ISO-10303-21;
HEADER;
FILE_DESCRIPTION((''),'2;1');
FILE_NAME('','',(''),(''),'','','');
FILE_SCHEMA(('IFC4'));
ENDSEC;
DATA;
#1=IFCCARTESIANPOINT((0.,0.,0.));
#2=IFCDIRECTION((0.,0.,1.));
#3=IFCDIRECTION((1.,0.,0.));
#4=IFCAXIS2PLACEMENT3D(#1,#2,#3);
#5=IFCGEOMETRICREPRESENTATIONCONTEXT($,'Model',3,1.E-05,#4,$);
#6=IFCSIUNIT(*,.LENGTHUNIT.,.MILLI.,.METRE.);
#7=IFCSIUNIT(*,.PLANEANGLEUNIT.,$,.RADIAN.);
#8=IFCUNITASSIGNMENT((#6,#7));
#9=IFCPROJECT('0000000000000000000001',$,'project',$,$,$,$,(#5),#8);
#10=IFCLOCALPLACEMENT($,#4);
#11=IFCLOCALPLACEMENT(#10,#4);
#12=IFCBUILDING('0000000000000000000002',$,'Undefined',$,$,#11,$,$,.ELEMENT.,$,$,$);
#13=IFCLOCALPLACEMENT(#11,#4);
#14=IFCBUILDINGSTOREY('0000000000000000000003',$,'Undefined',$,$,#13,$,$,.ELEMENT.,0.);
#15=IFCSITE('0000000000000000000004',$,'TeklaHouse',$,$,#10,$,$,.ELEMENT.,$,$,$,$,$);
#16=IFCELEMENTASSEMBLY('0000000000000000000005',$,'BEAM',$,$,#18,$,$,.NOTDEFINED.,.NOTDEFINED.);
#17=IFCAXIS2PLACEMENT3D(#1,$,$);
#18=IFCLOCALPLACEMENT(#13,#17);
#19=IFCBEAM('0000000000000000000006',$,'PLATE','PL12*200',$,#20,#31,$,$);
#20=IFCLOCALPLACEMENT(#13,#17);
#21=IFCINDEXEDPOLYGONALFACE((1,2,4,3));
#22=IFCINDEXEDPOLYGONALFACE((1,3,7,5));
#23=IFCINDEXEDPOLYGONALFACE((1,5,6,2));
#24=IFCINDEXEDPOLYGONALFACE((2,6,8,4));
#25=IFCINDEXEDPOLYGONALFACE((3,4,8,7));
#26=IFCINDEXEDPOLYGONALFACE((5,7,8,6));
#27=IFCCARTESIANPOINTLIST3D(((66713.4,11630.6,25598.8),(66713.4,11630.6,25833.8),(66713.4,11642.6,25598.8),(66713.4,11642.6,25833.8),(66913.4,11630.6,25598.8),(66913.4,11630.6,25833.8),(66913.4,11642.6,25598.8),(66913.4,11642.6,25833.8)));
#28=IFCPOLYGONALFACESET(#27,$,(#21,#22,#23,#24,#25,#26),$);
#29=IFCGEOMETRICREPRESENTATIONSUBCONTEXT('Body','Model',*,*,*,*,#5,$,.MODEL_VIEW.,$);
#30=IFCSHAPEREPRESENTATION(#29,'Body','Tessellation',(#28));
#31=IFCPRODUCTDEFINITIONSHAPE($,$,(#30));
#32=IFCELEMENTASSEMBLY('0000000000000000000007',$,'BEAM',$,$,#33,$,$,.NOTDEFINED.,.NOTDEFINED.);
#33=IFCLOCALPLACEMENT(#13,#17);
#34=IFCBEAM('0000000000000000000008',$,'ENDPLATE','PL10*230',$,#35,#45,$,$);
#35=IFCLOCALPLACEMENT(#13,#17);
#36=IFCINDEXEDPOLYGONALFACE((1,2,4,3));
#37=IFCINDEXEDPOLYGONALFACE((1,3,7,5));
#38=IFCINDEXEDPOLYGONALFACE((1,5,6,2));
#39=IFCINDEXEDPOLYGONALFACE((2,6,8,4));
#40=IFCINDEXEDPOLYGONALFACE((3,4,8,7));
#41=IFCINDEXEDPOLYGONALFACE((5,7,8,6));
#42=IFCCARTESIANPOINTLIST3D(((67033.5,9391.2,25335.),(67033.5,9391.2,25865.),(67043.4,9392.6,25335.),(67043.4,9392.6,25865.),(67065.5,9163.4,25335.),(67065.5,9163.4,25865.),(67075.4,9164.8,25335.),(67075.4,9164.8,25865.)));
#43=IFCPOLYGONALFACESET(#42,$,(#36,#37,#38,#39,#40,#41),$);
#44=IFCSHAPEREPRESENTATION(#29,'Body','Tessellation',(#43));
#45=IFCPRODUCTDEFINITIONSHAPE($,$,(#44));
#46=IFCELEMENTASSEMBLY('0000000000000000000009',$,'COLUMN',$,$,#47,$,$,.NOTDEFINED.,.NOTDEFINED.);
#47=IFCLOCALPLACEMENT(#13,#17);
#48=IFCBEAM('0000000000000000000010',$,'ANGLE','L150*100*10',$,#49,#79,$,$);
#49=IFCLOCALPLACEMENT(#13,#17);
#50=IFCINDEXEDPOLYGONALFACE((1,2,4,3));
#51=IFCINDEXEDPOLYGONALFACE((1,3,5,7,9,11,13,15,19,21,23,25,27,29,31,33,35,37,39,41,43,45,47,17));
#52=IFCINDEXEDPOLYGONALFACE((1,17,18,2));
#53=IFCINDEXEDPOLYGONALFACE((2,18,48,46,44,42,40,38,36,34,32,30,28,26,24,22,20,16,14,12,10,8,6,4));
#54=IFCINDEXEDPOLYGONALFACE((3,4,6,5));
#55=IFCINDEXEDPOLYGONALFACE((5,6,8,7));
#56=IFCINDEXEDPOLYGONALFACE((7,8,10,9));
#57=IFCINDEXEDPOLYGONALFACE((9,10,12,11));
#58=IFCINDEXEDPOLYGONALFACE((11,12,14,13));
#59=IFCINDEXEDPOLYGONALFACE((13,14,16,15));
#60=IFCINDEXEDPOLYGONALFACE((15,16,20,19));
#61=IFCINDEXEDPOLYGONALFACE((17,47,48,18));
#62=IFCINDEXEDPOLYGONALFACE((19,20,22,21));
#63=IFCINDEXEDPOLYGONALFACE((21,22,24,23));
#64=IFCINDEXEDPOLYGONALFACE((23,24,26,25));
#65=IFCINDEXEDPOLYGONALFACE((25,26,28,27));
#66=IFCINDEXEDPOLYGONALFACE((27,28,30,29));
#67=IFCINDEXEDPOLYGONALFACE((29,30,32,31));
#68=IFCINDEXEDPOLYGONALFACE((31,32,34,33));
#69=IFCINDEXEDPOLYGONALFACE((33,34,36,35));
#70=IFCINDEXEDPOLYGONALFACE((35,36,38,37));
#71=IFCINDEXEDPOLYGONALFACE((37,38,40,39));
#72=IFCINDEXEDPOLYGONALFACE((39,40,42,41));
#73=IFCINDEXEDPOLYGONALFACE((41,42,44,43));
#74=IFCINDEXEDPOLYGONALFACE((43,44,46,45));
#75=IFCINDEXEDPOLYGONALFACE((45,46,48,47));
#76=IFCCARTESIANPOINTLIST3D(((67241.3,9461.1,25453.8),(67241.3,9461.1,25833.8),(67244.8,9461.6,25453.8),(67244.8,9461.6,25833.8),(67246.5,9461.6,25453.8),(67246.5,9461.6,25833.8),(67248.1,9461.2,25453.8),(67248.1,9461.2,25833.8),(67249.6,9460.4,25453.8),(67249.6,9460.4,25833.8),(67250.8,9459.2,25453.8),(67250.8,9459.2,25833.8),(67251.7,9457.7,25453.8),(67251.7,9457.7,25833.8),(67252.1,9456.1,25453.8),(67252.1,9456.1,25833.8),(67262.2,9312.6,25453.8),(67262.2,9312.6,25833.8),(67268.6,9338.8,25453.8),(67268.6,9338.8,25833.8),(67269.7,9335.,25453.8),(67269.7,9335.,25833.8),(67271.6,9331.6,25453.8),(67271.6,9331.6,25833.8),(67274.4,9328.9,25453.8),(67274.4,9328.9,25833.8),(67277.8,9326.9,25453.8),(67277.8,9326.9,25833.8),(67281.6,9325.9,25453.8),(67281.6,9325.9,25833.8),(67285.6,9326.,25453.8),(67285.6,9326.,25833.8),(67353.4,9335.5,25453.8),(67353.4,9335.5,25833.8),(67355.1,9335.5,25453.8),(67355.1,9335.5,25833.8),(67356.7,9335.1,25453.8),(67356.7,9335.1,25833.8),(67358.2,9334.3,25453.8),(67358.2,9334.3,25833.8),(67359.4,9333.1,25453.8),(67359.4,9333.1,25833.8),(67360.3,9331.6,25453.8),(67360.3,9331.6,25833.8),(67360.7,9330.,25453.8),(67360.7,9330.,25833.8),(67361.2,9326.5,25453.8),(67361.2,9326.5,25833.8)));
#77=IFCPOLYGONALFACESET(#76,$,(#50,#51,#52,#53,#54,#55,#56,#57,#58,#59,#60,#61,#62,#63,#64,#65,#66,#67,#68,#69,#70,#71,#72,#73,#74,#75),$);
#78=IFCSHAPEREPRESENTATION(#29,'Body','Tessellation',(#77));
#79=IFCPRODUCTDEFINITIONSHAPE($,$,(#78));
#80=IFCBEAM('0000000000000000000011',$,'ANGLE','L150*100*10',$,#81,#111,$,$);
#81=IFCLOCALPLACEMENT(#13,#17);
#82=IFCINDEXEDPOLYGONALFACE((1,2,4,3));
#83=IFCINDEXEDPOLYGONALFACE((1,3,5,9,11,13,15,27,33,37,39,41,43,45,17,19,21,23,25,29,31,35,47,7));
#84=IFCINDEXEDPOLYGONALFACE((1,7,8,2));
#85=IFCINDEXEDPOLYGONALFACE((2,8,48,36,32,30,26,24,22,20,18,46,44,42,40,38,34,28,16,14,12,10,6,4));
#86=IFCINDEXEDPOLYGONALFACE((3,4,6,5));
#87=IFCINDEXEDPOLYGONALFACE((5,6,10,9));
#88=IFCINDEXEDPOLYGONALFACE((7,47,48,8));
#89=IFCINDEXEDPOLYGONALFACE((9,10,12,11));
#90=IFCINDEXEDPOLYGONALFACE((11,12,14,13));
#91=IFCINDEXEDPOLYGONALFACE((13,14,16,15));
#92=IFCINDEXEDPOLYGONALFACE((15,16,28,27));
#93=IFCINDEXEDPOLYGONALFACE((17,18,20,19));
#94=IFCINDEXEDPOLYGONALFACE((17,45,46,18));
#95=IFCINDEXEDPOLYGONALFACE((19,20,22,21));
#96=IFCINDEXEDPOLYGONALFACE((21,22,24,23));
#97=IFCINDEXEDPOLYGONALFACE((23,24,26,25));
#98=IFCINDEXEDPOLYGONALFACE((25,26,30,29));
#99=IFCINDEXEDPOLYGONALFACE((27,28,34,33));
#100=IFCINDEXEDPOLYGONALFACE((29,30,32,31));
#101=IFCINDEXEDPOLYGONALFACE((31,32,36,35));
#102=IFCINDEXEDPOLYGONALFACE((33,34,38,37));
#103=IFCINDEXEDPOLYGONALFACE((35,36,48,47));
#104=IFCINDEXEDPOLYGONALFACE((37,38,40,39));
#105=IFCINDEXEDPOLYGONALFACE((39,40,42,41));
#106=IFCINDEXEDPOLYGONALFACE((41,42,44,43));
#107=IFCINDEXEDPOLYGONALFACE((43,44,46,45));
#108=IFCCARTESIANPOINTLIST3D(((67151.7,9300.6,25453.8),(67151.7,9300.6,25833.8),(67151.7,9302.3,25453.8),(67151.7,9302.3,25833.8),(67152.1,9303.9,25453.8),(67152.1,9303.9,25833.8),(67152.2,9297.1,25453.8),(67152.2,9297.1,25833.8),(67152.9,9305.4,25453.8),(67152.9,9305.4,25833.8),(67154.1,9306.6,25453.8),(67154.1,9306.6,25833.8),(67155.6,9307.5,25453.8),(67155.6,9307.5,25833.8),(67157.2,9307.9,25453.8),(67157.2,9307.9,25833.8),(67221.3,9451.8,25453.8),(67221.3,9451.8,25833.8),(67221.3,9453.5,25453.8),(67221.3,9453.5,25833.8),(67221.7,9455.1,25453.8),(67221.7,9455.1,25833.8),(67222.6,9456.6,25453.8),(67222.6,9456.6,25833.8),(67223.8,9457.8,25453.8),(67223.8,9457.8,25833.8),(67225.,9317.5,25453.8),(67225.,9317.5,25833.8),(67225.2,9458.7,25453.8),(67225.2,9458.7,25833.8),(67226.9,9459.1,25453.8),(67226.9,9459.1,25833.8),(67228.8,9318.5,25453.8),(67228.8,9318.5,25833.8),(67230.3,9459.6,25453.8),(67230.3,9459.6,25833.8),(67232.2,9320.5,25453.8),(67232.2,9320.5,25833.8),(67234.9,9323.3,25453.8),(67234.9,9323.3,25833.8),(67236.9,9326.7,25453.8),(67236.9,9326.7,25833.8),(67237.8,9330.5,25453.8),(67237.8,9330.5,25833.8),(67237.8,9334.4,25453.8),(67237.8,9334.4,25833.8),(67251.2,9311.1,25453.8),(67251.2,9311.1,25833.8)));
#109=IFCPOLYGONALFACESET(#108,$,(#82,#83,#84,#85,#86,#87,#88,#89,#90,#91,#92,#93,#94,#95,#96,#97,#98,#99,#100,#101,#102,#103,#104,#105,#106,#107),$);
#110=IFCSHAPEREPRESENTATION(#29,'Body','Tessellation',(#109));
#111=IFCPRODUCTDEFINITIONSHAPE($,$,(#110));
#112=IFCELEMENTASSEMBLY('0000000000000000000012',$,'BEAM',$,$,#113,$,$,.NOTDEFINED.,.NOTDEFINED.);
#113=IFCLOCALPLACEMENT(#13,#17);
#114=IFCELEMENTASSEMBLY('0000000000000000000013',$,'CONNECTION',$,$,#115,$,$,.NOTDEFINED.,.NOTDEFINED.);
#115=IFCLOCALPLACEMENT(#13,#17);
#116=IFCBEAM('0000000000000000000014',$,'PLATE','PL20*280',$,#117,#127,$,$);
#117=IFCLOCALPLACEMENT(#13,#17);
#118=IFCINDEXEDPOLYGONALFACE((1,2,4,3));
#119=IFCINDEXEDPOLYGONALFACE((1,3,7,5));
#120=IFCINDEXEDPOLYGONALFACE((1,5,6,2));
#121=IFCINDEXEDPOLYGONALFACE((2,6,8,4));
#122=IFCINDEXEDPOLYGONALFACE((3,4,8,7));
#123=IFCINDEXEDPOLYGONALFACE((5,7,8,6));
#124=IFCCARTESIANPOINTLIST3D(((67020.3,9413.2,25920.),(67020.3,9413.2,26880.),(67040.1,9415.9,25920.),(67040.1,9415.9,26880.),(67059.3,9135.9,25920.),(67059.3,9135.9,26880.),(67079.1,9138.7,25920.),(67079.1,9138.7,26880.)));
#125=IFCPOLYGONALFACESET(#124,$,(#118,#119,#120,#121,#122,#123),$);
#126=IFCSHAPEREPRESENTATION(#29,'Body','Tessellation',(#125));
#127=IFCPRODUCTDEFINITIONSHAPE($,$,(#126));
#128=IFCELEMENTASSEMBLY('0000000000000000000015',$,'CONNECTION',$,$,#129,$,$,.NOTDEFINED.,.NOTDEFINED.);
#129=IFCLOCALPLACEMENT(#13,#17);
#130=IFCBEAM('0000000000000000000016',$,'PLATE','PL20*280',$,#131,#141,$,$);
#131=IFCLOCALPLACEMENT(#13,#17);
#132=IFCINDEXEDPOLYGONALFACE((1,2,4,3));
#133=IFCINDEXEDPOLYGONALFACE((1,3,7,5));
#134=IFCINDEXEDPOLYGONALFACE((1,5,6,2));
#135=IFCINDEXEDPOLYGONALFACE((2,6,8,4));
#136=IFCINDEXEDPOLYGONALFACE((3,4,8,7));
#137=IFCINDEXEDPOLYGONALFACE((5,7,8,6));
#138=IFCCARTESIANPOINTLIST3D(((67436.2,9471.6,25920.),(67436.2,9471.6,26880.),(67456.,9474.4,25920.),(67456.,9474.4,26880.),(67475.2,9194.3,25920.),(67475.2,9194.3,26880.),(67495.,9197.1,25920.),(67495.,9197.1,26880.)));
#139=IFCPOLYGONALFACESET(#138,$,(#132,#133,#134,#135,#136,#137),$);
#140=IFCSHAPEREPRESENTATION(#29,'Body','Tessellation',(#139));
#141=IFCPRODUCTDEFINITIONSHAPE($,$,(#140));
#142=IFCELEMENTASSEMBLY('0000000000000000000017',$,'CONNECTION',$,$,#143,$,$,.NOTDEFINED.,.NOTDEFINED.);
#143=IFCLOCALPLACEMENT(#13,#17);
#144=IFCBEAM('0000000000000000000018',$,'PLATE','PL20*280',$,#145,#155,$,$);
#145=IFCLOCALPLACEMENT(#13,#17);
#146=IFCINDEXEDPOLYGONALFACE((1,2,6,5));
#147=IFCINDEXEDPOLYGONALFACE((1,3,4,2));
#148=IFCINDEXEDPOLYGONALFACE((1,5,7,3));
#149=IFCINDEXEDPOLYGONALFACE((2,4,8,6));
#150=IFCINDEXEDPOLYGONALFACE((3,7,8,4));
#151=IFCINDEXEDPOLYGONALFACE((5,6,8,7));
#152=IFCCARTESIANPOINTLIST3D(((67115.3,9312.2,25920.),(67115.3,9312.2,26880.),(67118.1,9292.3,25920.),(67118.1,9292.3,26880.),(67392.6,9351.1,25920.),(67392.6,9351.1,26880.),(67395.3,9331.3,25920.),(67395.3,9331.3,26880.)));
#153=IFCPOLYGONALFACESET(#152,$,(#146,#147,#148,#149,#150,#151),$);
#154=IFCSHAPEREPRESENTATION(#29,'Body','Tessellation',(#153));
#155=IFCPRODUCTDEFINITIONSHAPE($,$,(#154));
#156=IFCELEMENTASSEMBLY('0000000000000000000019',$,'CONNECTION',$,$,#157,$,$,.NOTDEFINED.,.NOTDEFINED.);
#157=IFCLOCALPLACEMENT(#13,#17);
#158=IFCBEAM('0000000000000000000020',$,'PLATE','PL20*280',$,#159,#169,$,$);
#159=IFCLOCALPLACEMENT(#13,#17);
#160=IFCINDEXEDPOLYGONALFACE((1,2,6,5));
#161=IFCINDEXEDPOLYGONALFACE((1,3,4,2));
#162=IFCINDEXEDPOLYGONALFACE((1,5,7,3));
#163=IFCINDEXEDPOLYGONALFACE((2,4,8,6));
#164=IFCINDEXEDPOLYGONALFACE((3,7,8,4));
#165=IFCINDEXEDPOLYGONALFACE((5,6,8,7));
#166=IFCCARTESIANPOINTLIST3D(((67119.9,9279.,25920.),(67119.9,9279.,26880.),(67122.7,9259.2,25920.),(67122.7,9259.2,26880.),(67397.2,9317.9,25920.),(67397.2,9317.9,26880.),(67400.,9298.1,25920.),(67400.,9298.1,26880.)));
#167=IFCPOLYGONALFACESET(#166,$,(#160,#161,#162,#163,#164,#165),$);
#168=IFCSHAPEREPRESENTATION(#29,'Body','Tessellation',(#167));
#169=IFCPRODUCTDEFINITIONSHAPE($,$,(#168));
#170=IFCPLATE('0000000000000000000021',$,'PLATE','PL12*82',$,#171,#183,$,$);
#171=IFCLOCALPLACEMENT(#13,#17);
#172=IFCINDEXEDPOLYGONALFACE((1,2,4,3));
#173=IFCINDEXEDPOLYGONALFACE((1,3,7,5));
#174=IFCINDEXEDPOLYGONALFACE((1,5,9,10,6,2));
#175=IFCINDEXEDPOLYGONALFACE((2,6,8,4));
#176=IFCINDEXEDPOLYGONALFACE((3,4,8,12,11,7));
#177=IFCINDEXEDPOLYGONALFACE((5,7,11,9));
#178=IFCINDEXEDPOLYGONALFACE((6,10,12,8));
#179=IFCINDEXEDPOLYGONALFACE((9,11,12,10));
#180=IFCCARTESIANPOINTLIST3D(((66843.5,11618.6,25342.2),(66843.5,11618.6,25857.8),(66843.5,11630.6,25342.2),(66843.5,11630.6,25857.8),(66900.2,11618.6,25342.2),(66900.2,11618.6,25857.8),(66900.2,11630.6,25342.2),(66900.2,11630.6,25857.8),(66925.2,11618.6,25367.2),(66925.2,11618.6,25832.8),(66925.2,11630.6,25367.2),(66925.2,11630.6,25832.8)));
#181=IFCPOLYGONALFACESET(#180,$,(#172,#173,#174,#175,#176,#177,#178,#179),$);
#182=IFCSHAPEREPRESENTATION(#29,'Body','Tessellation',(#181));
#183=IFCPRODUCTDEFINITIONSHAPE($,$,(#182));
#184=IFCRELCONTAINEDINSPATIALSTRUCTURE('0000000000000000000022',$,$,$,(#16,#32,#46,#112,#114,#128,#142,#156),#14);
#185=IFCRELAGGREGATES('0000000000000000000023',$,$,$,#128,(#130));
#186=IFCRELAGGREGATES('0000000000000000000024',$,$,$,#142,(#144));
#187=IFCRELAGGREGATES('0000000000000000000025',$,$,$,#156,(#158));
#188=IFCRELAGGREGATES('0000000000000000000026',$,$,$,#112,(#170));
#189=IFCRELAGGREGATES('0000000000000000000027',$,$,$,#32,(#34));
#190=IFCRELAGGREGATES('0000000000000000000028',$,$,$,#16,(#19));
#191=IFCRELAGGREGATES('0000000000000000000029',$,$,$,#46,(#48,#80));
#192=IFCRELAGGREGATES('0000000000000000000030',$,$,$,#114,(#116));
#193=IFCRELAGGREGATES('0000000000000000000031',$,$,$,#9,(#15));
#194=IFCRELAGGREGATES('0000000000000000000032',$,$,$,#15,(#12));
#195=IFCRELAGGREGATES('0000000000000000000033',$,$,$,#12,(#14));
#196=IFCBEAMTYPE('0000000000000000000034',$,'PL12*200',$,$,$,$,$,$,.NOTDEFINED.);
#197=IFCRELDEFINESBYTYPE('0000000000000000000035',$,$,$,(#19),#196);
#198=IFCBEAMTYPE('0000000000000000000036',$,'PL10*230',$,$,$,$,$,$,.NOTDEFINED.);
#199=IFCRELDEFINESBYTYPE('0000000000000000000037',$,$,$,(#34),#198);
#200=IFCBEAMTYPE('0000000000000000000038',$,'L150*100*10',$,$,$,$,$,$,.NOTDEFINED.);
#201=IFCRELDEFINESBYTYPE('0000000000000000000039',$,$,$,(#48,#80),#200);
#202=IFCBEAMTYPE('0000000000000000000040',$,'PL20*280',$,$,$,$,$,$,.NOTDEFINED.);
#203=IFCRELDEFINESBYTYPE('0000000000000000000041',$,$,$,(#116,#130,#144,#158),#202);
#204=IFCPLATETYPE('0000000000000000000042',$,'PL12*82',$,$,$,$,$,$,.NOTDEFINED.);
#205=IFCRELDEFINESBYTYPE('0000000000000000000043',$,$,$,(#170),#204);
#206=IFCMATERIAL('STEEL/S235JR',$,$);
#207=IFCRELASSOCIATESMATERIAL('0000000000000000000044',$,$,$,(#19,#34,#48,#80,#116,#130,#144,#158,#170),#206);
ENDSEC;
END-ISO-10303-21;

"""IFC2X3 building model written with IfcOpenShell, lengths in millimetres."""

from ifc_helpers import new_model, si_unit, frame, origin_with_axes, origin_2d_with_axis, place, context, subcontext, project, spatial, polyline, rectangle, l_section, outline, extrude, material, type_object, element, aggregate, save


model = new_model("IFC2X3")

# Units and contexts
model_context = context("Model", 3, precision=1e-05, world=origin_with_axes())
body_context = subcontext(model_context, "Body", "Model", "MODEL_VIEW")
ifc_project = project(units=[si_unit("LENGTHUNIT", "METRE", prefix="MILLI"), si_unit("PLANEANGLEUNIT", "RADIAN")], contexts=[model_context])

# Site, building, storey
site_placement = place(None, origin_with_axes())
site = spatial("IfcSite", under=ifc_project, at=site_placement, Name="TeklaHouse", CompositionType="ELEMENT")
building_placement = place(site_placement, origin_with_axes())
building = spatial("IfcBuilding", under=site, at=building_placement, Name="Undefined", CompositionType="ELEMENT")
storey_placement = place(building_placement, origin_with_axes())
storey = spatial("IfcBuildingStorey", under=building, at=storey_placement, Name="Undefined", CompositionType="ELEMENT", Elevation=0.0)

# Element assemblies, beams
assembly_1_placement = place(storey_placement, origin_with_axes())
assembly_1 = element("IfcElementAssembly", 1, at=assembly_1_placement, inside=storey, Name="BEAM", AssemblyPlace="NOTDEFINED", PredefinedType="NOTDEFINED")
ifc_material_1 = material(Name="STEEL/S235JR")
beam_type_1 = type_object("IfcBeamType", Name="PL12*200", PredefinedType="NOTDEFINED")
beam_1_placement = place(assembly_1_placement, frame((66813.4, 11636.6, 25598.8), z_axis=(1.0, 0.0, 0.0), x_axis=(0.0, 0.0, 1.0)))
beam_1 = element("IfcBeam", 2, at=beam_1_placement, type_object=beam_type_1, material=ifc_material_1, Name="PLATE", Description="PL12*200", context=body_context, shape_type="SweptSolid", body=[
    extrude(rectangle(XDim=12.0, YDim=200.0, at=origin_2d_with_axis()), frame((235.0, 0.0, 0.0), z_axis=(-1.0, 0.0, 0.0), x_axis=(0.0, -1.0, 0.0)), (0.0, 0.0, 1.0), 235.0),
])
assembly_2_placement = place(storey_placement, origin_with_axes())
assembly_2 = element("IfcElementAssembly", 3, at=assembly_2_placement, inside=storey, Name="BEAM", AssemblyPlace="NOTDEFINED", PredefinedType="NOTDEFINED")
beam_type_2 = type_object("IfcBeamType", Name="PL10*230", PredefinedType="NOTDEFINED")
beam_2_placement = place(assembly_2_placement, frame((67054.4, 9278.0, 25335.0), z_axis=(-0.139172, 0.990268, 0.0), x_axis=(0.0, 0.0, 1.0)))
beam_2 = element("IfcBeam", 4, at=beam_2_placement, type_object=beam_type_2, material=ifc_material_1, Name="ENDPLATE", Description="PL10*230", context=body_context, shape_type="SweptSolid", body=[
    extrude(rectangle(XDim=10.0, YDim=230.0, at=origin_2d_with_axis()), frame((530.0, 0.0, 0.0), z_axis=(-1.0, 0.0, 0.0), x_axis=(0.0, -1.0, 0.0)), (0.0, 0.0, 1.0), 530.0),
])

# Element assembly, beams
assembly_3_placement = place(storey_placement, origin_with_axes())
assembly_3 = element("IfcElementAssembly", 5, at=assembly_3_placement, inside=storey, Name="COLUMN", AssemblyPlace="NOTDEFINED", PredefinedType="NOTDEFINED")
beam_type_3 = type_object("IfcBeamType", Name="L150*100*10", PredefinedType="NOTDEFINED")
beam_3_placement = place(assembly_3_placement, frame((67301.3, 9393.8, 25833.8), z_axis=(-0.139172, 0.990268, 0.0), x_axis=(0.0, 0.0, -1.0)))
beam_3 = element("IfcBeam", 6, at=beam_3_placement, type_object=beam_type_3, material=ifc_material_1, Name="ANGLE", Description="L150*100*10", context=body_context, shape_type="SweptSolid", body=[
    extrude(l_section(Depth=150.0, Width=100.0, Thickness=10.0, FilletRadius=15.0, EdgeRadius=6.5, at=origin_2d_with_axis()), frame((380.0, 0.0, 0.0), z_axis=(-1.0, 0.0, 0.0), x_axis=(0.0, -1.0, 0.0)), (0.0, 0.0, 1.0), 380.0),
])
beam_4_placement = place(assembly_3_placement, frame((67191.2, 9378.4, 25453.8), z_axis=(-0.139172, 0.990268, 0.0), x_axis=(0.0, 0.0, 1.0)))
beam_4 = element("IfcBeam", 7, at=beam_4_placement, type_object=beam_type_3, material=ifc_material_1, Name="ANGLE", Description="L150*100*10", context=body_context, shape_type="SweptSolid", body=[
    extrude(l_section(Depth=150.0, Width=100.0, Thickness=10.0, FilletRadius=15.0, EdgeRadius=6.5, at=origin_2d_with_axis()), frame((380.0, 0.0, 0.0), z_axis=(-1.0, 0.0, 0.0), x_axis=(0.0, -1.0, 0.0)), (0.0, 0.0, 1.0), 380.0),
])

# Element assemblies, beams
assembly_4_placement = place(storey_placement, origin_with_axes())
assembly_4 = element("IfcElementAssembly", 8, at=assembly_4_placement, inside=storey, Name="BEAM", AssemblyPlace="NOTDEFINED", PredefinedType="NOTDEFINED")
assembly_5_placement = place(storey_placement, origin_with_axes())
assembly_5 = element("IfcElementAssembly", 9, at=assembly_5_placement, inside=storey, Name="CONNECTION", AssemblyPlace="NOTDEFINED", PredefinedType="NOTDEFINED")
beam_type_4 = type_object("IfcBeamType", Name="PL20*280", PredefinedType="NOTDEFINED")
beam_5_placement = place(assembly_5_placement, frame((67049.7, 9275.9, 25920.0), z_axis=(-0.139172, 0.990268, 0.0), x_axis=(0.0, 0.0, 1.0)))
beam_5 = element("IfcBeam", 10, at=beam_5_placement, type_object=beam_type_4, material=ifc_material_1, Name="PLATE", Description="PL20*280", context=body_context, shape_type="SweptSolid", body=[
    extrude(rectangle(XDim=20.0, YDim=280.0, at=origin_2d_with_axis()), frame((960.0, 0.0, 0.0), z_axis=(-1.0, 0.0, 0.0), x_axis=(0.0, -1.0, 0.0)), (0.0, 0.0, 1.0), 960.0),
])
assembly_6_placement = place(storey_placement, origin_with_axes())
assembly_6 = element("IfcElementAssembly", 11, at=assembly_6_placement, inside=storey, Name="CONNECTION", AssemblyPlace="NOTDEFINED", PredefinedType="NOTDEFINED")
beam_6_placement = place(assembly_6_placement, frame((67465.6, 9334.4, 25920.0), z_axis=(0.139172, -0.990268, 0.0), x_axis=(0.0, 0.0, 1.0)))
beam_6 = element("IfcBeam", 12, at=beam_6_placement, type_object=beam_type_4, material=ifc_material_1, Name="PLATE", Description="PL20*280", context=body_context, shape_type="SweptSolid", body=[
    extrude(rectangle(XDim=20.0, YDim=280.0, at=origin_2d_with_axis()), frame((960.0, 0.0, 0.0), z_axis=(-1.0, 0.0, 0.0), x_axis=(0.0, -1.0, 0.0)), (0.0, 0.0, 1.0), 960.0),
])
aggregate(assembly_6, [beam_6])
assembly_7_placement = place(storey_placement, origin_with_axes())
assembly_7 = element("IfcElementAssembly", 13, at=assembly_7_placement, inside=storey, Name="CONNECTION", AssemblyPlace="NOTDEFINED", PredefinedType="NOTDEFINED")
beam_7_placement = place(assembly_7_placement, frame((67255.3, 9321.7, 25920.0), z_axis=(-0.990268, -0.139172, 0.0), x_axis=(0.0, 0.0, 1.0)))
beam_7 = element("IfcBeam", 14, at=beam_7_placement, type_object=beam_type_4, material=ifc_material_1, Name="PLATE", Description="PL20*280", context=body_context, shape_type="SweptSolid", body=[
    extrude(rectangle(XDim=20.0, YDim=280.0, at=origin_2d_with_axis()), frame((960.0, 0.0, 0.0), z_axis=(-1.0, 0.0, 0.0), x_axis=(0.0, -1.0, 0.0)), (0.0, 0.0, 1.0), 960.0),
])
aggregate(assembly_7, [beam_7])
assembly_8_placement = place(storey_placement, origin_with_axes())
assembly_8 = element("IfcElementAssembly", 15, at=assembly_8_placement, inside=storey, Name="CONNECTION", AssemblyPlace="NOTDEFINED", PredefinedType="NOTDEFINED")
beam_8_placement = place(assembly_8_placement, frame((67260.0, 9288.6, 25920.0), z_axis=(-0.990268, -0.139172, 0.0), x_axis=(0.0, 0.0, 1.0)))
beam_8 = element("IfcBeam", 16, at=beam_8_placement, type_object=beam_type_4, material=ifc_material_1, Name="PLATE", Description="PL20*280", context=body_context, shape_type="SweptSolid", body=[
    extrude(rectangle(XDim=20.0, YDim=280.0, at=origin_2d_with_axis()), frame((960.0, 0.0, 0.0), z_axis=(-1.0, 0.0, 0.0), x_axis=(0.0, -1.0, 0.0)), (0.0, 0.0, 1.0), 960.0),
])
aggregate(assembly_8, [beam_8])

# Plate
plate_type = type_object("IfcPlateType", Name="PL12*82", PredefinedType="NOTDEFINED")
plate_placement = place(assembly_4_placement, frame((66925.2, 11624.6, 25342.2), z_axis=(0.0, 1.0, 0.0), x_axis=(-1.0, 0.0, 0.0)))
plate = element("IfcPlate", 17, at=plate_placement, type_object=plate_type, material=ifc_material_1, Name="PLATE", Description="PL12*82", context=body_context, shape_type="SweptSolid", body=[
    extrude(outline(polyline([(0.0, 25.0), (25.0, 0.0), (81.7, 0.0), (81.7, 515.6), (25.0, 515.6), (0.0, 490.6), (0.0, 25.0)])), frame((0.0, 0.0, -6.0), z_axis=(0.0, 0.0, 1.0), x_axis=(1.0, 0.0, 0.0)), (0.0, 0.0, 1.0), 12.0),
])
aggregate(assembly_4, [plate])

aggregate(assembly_2, [beam_2])
aggregate(assembly_1, [beam_1])
aggregate(assembly_3, [beam_3, beam_4])

aggregate(assembly_5, [beam_5])

save(model, "model.ifc")
